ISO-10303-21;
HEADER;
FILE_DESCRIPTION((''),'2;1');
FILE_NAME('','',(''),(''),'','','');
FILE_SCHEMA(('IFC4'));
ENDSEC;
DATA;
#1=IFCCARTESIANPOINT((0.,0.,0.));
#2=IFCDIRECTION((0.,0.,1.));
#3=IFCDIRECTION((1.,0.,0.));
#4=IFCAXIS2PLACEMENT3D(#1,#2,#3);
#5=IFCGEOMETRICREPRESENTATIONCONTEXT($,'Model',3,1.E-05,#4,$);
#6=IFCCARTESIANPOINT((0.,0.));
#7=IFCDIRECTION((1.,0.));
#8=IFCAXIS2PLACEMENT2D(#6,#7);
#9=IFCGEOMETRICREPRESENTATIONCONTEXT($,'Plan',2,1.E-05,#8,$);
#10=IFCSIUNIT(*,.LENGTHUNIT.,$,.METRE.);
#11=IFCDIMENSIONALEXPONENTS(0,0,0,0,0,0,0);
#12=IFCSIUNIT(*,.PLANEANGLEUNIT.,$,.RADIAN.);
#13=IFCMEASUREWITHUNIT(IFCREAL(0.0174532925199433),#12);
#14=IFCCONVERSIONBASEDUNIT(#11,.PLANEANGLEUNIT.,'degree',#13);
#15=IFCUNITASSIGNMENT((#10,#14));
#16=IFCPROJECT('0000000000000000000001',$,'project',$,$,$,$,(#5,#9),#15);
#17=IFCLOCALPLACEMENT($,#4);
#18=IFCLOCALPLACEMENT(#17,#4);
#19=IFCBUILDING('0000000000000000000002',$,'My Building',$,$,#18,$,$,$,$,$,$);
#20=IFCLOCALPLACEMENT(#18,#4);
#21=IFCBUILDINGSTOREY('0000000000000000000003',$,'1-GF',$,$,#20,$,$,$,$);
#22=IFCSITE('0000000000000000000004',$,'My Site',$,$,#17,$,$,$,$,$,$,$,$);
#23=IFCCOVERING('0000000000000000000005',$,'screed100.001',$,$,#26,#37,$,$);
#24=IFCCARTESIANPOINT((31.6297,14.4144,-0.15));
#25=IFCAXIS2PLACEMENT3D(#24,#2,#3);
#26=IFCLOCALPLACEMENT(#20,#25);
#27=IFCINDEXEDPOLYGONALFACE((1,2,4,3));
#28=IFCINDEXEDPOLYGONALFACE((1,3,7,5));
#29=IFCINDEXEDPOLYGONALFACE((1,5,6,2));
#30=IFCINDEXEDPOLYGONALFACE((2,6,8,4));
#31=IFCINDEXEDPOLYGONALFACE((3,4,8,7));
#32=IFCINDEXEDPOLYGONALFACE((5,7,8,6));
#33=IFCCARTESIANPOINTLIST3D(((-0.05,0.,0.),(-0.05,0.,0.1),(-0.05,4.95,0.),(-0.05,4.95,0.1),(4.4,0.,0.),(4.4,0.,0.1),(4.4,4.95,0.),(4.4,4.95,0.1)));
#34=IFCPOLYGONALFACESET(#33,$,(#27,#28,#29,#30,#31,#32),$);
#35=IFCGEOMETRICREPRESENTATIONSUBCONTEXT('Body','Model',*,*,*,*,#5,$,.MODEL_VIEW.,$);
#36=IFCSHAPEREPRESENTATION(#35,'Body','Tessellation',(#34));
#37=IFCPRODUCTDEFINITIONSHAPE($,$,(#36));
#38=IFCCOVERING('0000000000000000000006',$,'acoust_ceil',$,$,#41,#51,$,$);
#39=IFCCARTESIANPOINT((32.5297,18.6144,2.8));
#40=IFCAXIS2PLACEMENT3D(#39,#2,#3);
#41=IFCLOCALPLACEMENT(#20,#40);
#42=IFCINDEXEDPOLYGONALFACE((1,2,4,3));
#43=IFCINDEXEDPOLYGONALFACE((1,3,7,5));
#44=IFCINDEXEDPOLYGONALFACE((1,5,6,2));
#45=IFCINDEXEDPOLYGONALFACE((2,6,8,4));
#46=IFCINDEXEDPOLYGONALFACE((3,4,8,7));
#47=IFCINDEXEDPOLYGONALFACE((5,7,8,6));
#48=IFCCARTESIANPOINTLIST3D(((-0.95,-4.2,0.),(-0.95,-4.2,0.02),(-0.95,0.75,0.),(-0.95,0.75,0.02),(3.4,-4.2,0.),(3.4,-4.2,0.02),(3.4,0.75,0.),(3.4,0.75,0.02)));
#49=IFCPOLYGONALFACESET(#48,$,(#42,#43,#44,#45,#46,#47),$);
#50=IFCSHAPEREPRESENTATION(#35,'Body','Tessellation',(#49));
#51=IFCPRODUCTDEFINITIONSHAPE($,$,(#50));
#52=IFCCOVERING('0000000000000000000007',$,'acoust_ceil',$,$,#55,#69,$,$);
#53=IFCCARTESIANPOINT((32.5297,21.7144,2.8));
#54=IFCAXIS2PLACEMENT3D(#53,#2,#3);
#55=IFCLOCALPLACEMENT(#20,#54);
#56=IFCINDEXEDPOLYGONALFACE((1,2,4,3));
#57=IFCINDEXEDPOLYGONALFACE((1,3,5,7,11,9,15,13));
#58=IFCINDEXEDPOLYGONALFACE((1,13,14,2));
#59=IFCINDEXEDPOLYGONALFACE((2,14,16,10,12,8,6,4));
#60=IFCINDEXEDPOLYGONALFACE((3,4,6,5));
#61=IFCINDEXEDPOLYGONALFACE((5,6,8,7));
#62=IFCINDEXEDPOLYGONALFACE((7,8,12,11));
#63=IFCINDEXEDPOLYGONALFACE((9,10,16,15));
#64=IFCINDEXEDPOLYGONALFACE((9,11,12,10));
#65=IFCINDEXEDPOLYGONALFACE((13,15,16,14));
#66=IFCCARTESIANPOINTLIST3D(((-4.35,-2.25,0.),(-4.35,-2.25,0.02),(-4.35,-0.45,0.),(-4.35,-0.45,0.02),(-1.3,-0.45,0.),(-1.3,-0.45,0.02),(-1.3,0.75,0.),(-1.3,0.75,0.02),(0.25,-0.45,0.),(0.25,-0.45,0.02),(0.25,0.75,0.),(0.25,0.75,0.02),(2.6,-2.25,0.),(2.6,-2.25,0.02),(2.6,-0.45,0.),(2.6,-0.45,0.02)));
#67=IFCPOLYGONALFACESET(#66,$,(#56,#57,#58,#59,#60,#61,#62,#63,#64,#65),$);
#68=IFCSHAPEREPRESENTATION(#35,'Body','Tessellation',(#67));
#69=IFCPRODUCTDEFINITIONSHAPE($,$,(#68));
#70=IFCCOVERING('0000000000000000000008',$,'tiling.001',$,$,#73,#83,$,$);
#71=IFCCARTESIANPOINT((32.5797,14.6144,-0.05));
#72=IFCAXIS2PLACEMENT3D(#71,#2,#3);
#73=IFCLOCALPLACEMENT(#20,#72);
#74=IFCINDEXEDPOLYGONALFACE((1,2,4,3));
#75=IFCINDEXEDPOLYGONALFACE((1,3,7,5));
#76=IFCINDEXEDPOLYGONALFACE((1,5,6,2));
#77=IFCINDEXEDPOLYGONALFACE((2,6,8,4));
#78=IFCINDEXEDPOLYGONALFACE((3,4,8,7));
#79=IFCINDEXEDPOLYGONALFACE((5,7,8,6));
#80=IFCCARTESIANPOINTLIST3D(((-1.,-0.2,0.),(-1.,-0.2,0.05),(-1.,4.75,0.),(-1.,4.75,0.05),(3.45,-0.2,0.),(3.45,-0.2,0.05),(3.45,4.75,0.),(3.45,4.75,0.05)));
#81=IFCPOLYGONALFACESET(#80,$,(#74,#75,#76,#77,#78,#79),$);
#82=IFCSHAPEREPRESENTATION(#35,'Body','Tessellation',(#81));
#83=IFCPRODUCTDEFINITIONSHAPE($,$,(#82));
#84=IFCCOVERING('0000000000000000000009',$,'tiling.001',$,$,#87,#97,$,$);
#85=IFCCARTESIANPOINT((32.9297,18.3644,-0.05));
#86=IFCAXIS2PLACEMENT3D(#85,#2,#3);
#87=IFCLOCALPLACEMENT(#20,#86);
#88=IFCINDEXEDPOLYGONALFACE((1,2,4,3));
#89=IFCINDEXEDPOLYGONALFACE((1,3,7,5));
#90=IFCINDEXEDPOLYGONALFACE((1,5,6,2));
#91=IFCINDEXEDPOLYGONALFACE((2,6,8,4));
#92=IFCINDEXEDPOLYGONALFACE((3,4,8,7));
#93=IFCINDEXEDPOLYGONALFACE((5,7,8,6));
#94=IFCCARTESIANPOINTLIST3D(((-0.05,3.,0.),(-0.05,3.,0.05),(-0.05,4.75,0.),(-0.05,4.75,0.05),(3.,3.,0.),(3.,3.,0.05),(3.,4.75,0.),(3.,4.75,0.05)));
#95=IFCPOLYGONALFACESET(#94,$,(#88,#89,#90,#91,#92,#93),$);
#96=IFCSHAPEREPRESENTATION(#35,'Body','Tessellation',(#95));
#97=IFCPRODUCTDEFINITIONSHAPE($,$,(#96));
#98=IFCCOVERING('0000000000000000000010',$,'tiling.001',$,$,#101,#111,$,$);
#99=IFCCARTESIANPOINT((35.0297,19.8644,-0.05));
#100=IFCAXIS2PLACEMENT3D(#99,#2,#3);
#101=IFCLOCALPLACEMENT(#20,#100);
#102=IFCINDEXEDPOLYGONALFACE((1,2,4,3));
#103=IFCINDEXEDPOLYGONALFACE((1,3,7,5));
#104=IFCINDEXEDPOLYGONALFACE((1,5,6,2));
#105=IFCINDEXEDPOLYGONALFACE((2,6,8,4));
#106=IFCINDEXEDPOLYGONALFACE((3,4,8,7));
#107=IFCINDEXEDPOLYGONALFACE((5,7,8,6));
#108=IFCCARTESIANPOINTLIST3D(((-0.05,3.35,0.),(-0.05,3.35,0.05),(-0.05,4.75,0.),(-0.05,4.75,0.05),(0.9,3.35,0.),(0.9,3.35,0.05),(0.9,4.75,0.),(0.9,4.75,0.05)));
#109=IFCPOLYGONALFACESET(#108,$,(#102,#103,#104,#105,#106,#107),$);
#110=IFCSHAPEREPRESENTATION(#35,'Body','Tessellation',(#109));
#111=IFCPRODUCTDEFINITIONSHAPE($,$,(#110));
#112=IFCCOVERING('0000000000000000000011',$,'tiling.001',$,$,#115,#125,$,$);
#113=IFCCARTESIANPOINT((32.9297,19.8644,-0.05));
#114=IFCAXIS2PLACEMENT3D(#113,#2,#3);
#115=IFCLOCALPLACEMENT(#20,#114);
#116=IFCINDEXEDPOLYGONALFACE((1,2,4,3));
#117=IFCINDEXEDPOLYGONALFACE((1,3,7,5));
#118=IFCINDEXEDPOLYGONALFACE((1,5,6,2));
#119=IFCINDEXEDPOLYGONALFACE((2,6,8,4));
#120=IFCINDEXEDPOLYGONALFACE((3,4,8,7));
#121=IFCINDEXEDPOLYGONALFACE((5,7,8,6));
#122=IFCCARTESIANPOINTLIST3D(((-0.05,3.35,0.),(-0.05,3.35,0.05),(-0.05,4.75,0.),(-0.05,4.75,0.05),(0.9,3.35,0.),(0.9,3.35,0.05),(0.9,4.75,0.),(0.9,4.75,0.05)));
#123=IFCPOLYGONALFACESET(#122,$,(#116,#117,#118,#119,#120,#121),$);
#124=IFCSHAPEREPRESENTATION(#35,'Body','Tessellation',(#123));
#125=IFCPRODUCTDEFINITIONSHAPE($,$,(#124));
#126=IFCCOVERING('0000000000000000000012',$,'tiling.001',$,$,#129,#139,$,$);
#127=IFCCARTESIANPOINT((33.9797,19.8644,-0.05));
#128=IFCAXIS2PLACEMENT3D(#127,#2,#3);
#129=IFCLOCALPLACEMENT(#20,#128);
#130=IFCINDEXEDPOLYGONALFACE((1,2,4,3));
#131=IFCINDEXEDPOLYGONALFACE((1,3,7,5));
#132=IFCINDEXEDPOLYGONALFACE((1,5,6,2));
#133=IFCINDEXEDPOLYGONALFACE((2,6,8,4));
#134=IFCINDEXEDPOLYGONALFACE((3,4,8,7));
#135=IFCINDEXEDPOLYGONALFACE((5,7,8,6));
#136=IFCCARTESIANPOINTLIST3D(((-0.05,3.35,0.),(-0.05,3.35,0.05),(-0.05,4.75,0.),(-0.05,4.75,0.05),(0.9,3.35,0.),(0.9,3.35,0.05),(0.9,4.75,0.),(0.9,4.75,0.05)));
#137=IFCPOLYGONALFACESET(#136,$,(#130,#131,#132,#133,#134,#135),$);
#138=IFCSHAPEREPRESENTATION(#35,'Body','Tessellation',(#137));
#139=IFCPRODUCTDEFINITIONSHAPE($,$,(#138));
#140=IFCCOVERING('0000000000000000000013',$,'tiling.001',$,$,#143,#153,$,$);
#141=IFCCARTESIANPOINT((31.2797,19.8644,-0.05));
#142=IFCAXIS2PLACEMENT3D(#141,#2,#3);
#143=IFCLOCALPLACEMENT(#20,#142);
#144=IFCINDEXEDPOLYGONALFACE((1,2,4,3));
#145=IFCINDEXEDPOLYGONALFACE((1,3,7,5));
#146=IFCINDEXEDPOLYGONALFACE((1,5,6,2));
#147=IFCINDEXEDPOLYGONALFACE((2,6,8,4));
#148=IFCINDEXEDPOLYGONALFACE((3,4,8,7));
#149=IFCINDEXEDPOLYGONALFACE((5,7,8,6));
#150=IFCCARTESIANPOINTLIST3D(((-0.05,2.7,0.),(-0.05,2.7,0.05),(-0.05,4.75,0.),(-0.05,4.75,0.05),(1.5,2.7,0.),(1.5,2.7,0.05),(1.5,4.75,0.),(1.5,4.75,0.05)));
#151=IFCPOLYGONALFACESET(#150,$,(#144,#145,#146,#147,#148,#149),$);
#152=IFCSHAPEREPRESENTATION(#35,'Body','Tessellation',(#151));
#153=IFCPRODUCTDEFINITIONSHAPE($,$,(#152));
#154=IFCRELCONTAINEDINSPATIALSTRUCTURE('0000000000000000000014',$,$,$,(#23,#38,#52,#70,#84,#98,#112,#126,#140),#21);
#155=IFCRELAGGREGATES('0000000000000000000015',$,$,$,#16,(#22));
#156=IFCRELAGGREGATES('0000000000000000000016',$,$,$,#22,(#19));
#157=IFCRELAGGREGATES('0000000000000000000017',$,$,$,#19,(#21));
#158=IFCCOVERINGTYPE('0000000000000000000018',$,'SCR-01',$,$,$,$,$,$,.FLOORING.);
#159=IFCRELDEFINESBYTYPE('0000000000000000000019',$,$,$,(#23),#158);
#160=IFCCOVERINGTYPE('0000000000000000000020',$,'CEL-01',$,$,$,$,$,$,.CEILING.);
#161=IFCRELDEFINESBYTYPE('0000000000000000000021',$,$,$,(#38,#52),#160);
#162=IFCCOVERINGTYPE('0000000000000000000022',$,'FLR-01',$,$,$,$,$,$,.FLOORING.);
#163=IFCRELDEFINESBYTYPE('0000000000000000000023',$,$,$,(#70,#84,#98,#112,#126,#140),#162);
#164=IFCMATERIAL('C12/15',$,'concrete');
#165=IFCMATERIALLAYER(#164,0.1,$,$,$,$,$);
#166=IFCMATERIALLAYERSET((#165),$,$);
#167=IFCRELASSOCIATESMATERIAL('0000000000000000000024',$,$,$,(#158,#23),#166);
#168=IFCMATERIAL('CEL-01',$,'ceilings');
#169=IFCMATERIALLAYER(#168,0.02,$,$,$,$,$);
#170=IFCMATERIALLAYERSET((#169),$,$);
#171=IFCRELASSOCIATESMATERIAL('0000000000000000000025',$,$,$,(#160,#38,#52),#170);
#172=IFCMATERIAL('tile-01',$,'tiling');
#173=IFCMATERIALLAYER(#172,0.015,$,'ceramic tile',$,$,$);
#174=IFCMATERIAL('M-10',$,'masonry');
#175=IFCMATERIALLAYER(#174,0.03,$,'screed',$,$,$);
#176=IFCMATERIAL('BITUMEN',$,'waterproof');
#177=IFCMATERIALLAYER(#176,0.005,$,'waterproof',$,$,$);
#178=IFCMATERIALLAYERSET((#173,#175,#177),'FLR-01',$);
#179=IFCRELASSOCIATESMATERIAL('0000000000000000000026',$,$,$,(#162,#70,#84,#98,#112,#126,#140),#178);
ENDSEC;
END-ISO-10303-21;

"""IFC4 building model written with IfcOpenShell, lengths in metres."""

from ifc_helpers import new_model, entity, si_unit, converted_unit, frame, origin_with_axes, origin_2d_with_axis, place, context, subcontext, project, spatial, line, indexed_curve, outline, extrude, material, layer, layer_set, layer_usage, type_object, element, save


model = new_model("IFC4")

# Units and contexts
model_context = context("Model", 3, precision=1e-05, world=origin_with_axes())
plan_context = context("Plan", 2, precision=1e-05, world=origin_2d_with_axis())
body_context_1 = subcontext(model_context, "Body", "Model", "MODEL_VIEW")
ifc_project = project(units=[si_unit("LENGTHUNIT", "METRE"), converted_unit("PLANEANGLEUNIT", "degree", entity("IfcReal", 0.0174532925199433), si_unit("PLANEANGLEUNIT", "RADIAN"), dimensions=[0, 0, 0, 0, 0, 0, 0])], contexts=[model_context, plan_context])

# Site, building, storey
site_placement = place(None, origin_with_axes())
site = spatial("IfcSite", under=ifc_project, at=site_placement, Name="My Site")
building_placement = place(site_placement, origin_with_axes())
building = spatial("IfcBuilding", under=site, at=building_placement, Name="My Building")
storey_placement = place(building_placement, origin_with_axes())
storey = spatial("IfcBuildingStorey", under=building, at=storey_placement, Name="1-GF")

# Coverings
ifc_material_1 = material(Name="C12/15", Category="concrete")
ifc_layer_1 = layer(ifc_material_1, 0.1)
ifc_layer_set_1 = layer_set([ifc_layer_1])
ifc_layer_usage_1 = layer_usage(ifc_layer_set_1, "AXIS3", "POSITIVE", 0.0)
covering_type_1 = type_object("IfcCoveringType", Name="SCR-01", PredefinedType="FLOORING", material=ifc_layer_set_1)
covering_1_placement = place(storey_placement, frame((31.6297, 14.4144, -0.15), z_axis=(0.0, 0.0, 1.0), x_axis=(1.0, 0.0, 0.0)))
element("IfcCovering", 1, at=covering_1_placement, inside=storey, type_object=covering_type_1, material=ifc_layer_usage_1, Name="screed100.001", context=body_context_1, shape_type="SweptSolid", body=[
    extrude(outline(indexed_curve([(-0.05, 0.0), (4.4, 0.0), (4.4, 4.95), (-0.05, 4.95)], segments=[line(3, 2), line(2, 1), line(1, 4), line(4, 3)], self_intersect=False)), None, (0.0, 0.0, 1.0), 0.1),
])
ifc_material_2 = material(Name="CEL-01", Category="ceilings")
ifc_layer_2 = layer(ifc_material_2, 0.02)
ifc_layer_set_2 = layer_set([ifc_layer_2])
ifc_layer_usage_2 = layer_usage(ifc_layer_set_2, "AXIS3", "POSITIVE", 0.0)
covering_type_2 = type_object("IfcCoveringType", Name="CEL-01", PredefinedType="CEILING", material=ifc_layer_set_2)
covering_2_placement = place(storey_placement, frame((32.5297, 18.6144, 2.8), z_axis=(0.0, 0.0, 1.0), x_axis=(1.0, 0.0, 0.0)))
element("IfcCovering", 2, at=covering_2_placement, inside=storey, type_object=covering_type_2, material=ifc_layer_usage_2, Name="acoust_ceil", context=body_context_1, shape_type="SweptSolid", body=[
    extrude(outline(indexed_curve([(3.4, 0.75), (3.4, -4.2), (-0.95, -4.2), (-0.95, 0.75)], segments=[line(3, 2), line(2, 1), line(1, 4), line(4, 3)], self_intersect=False)), None, (0.0, 0.0, 1.0), 0.02),
])
ifc_layer_usage_3 = layer_usage(ifc_layer_set_2, "AXIS3", "POSITIVE", 0.0)
covering_3_placement = place(storey_placement, frame((32.5297, 21.7144, 2.8), z_axis=(0.0, 0.0, 1.0), x_axis=(1.0, 0.0, 0.0)))
element("IfcCovering", 3, at=covering_3_placement, inside=storey, type_object=covering_type_2, material=ifc_layer_usage_3, Name="acoust_ceil", context=body_context_1, shape_type="SweptSolid", body=[
    extrude(outline(indexed_curve([(-4.35, -2.25), (2.6, -2.25), (2.6, -0.45), (-4.35, -0.45), (-1.3, -0.45), (0.25, -0.45), (-1.3, 0.75), (0.25, 0.75)], segments=[line(1, 2), line(2, 3), line(3, 6), line(6, 8), line(8, 7), line(7, 5), line(5, 4), line(4, 1)], self_intersect=False)), None, (0.0, 0.0, 1.0), 0.02),
])
ifc_material_3 = material(Name="tile-01", Category="tiling")
ifc_layer_3 = layer(ifc_material_3, 0.015, Name="ceramic tile")
ifc_material_4 = material(Name="M-10", Category="masonry")
ifc_layer_4 = layer(ifc_material_4, 0.03, Name="screed")
ifc_material_5 = material(Name="BITUMEN", Category="waterproof")
ifc_layer_5 = layer(ifc_material_5, 0.005, Name="waterproof")
ifc_layer_set_3 = layer_set([ifc_layer_3, ifc_layer_4, ifc_layer_5], Name="FLR-01")
ifc_layer_usage_4 = layer_usage(ifc_layer_set_3, "AXIS3", "POSITIVE", 0.0)
covering_type_3 = type_object("IfcCoveringType", Name="FLR-01", PredefinedType="FLOORING", material=ifc_layer_set_3)
covering_4_placement = place(storey_placement, frame((32.5797, 14.6144, -0.05), z_axis=(0.0, 0.0, 1.0), x_axis=(1.0, 0.0, 0.0)))
element("IfcCovering", 4, at=covering_4_placement, inside=storey, type_object=covering_type_3, material=ifc_layer_usage_4, Name="tiling.001", context=body_context_1, shape_type="SweptSolid", body=[
    extrude(outline(indexed_curve([(-1.0, 4.75), (-1.0, -0.2), (3.45, -0.2), (3.45, 4.75)], segments=[line(3, 2), line(2, 1), line(1, 4), line(4, 3)], self_intersect=False)), None, (0.0, 0.0, 1.0), 0.05),
])
ifc_layer_usage_5 = layer_usage(ifc_layer_set_3, "AXIS3", "POSITIVE", 0.0)
covering_5_placement = place(storey_placement, frame((32.9297, 18.3644, -0.05), z_axis=(0.0, 0.0, 1.0), x_axis=(1.0, 0.0, 0.0)))
element("IfcCovering", 5, at=covering_5_placement, inside=storey, type_object=covering_type_3, material=ifc_layer_usage_5, Name="tiling.001", context=body_context_1, shape_type="SweptSolid", body=[
    extrude(outline(indexed_curve([(3.0, 3.0), (-0.05, 3.0), (-0.05, 4.75), (3.0, 4.75)], segments=[line(4, 1), line(1, 2), line(2, 3), line(3, 4)], self_intersect=False)), None, (0.0, 0.0, 1.0), 0.05),
])
ifc_layer_usage_6 = layer_usage(ifc_layer_set_3, "AXIS3", "POSITIVE", 0.0)
covering_6_placement = place(storey_placement, frame((35.0297, 19.8644, -0.05), z_axis=(0.0, 0.0, 1.0), x_axis=(1.0, 0.0, 0.0)))
element("IfcCovering", 6, at=covering_6_placement, inside=storey, type_object=covering_type_3, material=ifc_layer_usage_6, Name="tiling.001", context=body_context_1, shape_type="SweptSolid", body=[
    extrude(outline(indexed_curve([(0.9, 4.75), (0.9, 3.35), (-0.05, 3.35), (-0.05, 4.75)], segments=[line(4, 1), line(1, 2), line(2, 3), line(3, 4)], self_intersect=False)), None, (0.0, 0.0, 1.0), 0.05),
])
ifc_layer_usage_7 = layer_usage(ifc_layer_set_3, "AXIS3", "POSITIVE", 0.0)
covering_7_placement = place(storey_placement, frame((32.9297, 19.8644, -0.05), z_axis=(0.0, 0.0, 1.0), x_axis=(1.0, 0.0, 0.0)))
element("IfcCovering", 7, at=covering_7_placement, inside=storey, type_object=covering_type_3, material=ifc_layer_usage_7, Name="tiling.001", context=body_context_1, shape_type="SweptSolid", body=[
    extrude(outline(indexed_curve([(0.9, 4.75), (0.9, 3.35), (-0.05, 3.35), (-0.05, 4.75)], segments=[line(4, 1), line(1, 2), line(2, 3), line(3, 4)], self_intersect=False)), None, (0.0, 0.0, 1.0), 0.05),
])
ifc_layer_usage_8 = layer_usage(ifc_layer_set_3, "AXIS3", "POSITIVE", 0.0)
covering_8_placement = place(storey_placement, frame((33.9797, 19.8644, -0.05), z_axis=(0.0, 0.0, 1.0), x_axis=(1.0, 0.0, 0.0)))
element("IfcCovering", 8, at=covering_8_placement, inside=storey, type_object=covering_type_3, material=ifc_layer_usage_8, Name="tiling.001", context=body_context_1, shape_type="SweptSolid", body=[
    extrude(outline(indexed_curve([(0.9, 4.75), (0.9, 3.35), (-0.05, 3.35), (-0.05, 4.75)], segments=[line(4, 1), line(1, 2), line(2, 3), line(3, 4)], self_intersect=False)), None, (0.0, 0.0, 1.0), 0.05),
])
ifc_layer_usage_9 = layer_usage(ifc_layer_set_3, "AXIS3", "POSITIVE", 0.0)
covering_9_placement = place(storey_placement, frame((31.2797, 19.8644, -0.05), z_axis=(0.0, 0.0, 1.0), x_axis=(1.0, 0.0, 0.0)))
element("IfcCovering", 9, at=covering_9_placement, inside=storey, type_object=covering_type_3, material=ifc_layer_usage_9, Name="tiling.001", context=body_context_1, shape_type="SweptSolid", body=[
    extrude(outline(indexed_curve([(-0.05, 4.75), (1.5, 4.75), (1.5, 2.7), (-0.05, 2.7)], segments=[line(3, 2), line(2, 1), line(1, 4), line(4, 3)], self_intersect=False)), None, (0.0, 0.0, 1.0), 0.05),
])

save(model, "model.ifc")
